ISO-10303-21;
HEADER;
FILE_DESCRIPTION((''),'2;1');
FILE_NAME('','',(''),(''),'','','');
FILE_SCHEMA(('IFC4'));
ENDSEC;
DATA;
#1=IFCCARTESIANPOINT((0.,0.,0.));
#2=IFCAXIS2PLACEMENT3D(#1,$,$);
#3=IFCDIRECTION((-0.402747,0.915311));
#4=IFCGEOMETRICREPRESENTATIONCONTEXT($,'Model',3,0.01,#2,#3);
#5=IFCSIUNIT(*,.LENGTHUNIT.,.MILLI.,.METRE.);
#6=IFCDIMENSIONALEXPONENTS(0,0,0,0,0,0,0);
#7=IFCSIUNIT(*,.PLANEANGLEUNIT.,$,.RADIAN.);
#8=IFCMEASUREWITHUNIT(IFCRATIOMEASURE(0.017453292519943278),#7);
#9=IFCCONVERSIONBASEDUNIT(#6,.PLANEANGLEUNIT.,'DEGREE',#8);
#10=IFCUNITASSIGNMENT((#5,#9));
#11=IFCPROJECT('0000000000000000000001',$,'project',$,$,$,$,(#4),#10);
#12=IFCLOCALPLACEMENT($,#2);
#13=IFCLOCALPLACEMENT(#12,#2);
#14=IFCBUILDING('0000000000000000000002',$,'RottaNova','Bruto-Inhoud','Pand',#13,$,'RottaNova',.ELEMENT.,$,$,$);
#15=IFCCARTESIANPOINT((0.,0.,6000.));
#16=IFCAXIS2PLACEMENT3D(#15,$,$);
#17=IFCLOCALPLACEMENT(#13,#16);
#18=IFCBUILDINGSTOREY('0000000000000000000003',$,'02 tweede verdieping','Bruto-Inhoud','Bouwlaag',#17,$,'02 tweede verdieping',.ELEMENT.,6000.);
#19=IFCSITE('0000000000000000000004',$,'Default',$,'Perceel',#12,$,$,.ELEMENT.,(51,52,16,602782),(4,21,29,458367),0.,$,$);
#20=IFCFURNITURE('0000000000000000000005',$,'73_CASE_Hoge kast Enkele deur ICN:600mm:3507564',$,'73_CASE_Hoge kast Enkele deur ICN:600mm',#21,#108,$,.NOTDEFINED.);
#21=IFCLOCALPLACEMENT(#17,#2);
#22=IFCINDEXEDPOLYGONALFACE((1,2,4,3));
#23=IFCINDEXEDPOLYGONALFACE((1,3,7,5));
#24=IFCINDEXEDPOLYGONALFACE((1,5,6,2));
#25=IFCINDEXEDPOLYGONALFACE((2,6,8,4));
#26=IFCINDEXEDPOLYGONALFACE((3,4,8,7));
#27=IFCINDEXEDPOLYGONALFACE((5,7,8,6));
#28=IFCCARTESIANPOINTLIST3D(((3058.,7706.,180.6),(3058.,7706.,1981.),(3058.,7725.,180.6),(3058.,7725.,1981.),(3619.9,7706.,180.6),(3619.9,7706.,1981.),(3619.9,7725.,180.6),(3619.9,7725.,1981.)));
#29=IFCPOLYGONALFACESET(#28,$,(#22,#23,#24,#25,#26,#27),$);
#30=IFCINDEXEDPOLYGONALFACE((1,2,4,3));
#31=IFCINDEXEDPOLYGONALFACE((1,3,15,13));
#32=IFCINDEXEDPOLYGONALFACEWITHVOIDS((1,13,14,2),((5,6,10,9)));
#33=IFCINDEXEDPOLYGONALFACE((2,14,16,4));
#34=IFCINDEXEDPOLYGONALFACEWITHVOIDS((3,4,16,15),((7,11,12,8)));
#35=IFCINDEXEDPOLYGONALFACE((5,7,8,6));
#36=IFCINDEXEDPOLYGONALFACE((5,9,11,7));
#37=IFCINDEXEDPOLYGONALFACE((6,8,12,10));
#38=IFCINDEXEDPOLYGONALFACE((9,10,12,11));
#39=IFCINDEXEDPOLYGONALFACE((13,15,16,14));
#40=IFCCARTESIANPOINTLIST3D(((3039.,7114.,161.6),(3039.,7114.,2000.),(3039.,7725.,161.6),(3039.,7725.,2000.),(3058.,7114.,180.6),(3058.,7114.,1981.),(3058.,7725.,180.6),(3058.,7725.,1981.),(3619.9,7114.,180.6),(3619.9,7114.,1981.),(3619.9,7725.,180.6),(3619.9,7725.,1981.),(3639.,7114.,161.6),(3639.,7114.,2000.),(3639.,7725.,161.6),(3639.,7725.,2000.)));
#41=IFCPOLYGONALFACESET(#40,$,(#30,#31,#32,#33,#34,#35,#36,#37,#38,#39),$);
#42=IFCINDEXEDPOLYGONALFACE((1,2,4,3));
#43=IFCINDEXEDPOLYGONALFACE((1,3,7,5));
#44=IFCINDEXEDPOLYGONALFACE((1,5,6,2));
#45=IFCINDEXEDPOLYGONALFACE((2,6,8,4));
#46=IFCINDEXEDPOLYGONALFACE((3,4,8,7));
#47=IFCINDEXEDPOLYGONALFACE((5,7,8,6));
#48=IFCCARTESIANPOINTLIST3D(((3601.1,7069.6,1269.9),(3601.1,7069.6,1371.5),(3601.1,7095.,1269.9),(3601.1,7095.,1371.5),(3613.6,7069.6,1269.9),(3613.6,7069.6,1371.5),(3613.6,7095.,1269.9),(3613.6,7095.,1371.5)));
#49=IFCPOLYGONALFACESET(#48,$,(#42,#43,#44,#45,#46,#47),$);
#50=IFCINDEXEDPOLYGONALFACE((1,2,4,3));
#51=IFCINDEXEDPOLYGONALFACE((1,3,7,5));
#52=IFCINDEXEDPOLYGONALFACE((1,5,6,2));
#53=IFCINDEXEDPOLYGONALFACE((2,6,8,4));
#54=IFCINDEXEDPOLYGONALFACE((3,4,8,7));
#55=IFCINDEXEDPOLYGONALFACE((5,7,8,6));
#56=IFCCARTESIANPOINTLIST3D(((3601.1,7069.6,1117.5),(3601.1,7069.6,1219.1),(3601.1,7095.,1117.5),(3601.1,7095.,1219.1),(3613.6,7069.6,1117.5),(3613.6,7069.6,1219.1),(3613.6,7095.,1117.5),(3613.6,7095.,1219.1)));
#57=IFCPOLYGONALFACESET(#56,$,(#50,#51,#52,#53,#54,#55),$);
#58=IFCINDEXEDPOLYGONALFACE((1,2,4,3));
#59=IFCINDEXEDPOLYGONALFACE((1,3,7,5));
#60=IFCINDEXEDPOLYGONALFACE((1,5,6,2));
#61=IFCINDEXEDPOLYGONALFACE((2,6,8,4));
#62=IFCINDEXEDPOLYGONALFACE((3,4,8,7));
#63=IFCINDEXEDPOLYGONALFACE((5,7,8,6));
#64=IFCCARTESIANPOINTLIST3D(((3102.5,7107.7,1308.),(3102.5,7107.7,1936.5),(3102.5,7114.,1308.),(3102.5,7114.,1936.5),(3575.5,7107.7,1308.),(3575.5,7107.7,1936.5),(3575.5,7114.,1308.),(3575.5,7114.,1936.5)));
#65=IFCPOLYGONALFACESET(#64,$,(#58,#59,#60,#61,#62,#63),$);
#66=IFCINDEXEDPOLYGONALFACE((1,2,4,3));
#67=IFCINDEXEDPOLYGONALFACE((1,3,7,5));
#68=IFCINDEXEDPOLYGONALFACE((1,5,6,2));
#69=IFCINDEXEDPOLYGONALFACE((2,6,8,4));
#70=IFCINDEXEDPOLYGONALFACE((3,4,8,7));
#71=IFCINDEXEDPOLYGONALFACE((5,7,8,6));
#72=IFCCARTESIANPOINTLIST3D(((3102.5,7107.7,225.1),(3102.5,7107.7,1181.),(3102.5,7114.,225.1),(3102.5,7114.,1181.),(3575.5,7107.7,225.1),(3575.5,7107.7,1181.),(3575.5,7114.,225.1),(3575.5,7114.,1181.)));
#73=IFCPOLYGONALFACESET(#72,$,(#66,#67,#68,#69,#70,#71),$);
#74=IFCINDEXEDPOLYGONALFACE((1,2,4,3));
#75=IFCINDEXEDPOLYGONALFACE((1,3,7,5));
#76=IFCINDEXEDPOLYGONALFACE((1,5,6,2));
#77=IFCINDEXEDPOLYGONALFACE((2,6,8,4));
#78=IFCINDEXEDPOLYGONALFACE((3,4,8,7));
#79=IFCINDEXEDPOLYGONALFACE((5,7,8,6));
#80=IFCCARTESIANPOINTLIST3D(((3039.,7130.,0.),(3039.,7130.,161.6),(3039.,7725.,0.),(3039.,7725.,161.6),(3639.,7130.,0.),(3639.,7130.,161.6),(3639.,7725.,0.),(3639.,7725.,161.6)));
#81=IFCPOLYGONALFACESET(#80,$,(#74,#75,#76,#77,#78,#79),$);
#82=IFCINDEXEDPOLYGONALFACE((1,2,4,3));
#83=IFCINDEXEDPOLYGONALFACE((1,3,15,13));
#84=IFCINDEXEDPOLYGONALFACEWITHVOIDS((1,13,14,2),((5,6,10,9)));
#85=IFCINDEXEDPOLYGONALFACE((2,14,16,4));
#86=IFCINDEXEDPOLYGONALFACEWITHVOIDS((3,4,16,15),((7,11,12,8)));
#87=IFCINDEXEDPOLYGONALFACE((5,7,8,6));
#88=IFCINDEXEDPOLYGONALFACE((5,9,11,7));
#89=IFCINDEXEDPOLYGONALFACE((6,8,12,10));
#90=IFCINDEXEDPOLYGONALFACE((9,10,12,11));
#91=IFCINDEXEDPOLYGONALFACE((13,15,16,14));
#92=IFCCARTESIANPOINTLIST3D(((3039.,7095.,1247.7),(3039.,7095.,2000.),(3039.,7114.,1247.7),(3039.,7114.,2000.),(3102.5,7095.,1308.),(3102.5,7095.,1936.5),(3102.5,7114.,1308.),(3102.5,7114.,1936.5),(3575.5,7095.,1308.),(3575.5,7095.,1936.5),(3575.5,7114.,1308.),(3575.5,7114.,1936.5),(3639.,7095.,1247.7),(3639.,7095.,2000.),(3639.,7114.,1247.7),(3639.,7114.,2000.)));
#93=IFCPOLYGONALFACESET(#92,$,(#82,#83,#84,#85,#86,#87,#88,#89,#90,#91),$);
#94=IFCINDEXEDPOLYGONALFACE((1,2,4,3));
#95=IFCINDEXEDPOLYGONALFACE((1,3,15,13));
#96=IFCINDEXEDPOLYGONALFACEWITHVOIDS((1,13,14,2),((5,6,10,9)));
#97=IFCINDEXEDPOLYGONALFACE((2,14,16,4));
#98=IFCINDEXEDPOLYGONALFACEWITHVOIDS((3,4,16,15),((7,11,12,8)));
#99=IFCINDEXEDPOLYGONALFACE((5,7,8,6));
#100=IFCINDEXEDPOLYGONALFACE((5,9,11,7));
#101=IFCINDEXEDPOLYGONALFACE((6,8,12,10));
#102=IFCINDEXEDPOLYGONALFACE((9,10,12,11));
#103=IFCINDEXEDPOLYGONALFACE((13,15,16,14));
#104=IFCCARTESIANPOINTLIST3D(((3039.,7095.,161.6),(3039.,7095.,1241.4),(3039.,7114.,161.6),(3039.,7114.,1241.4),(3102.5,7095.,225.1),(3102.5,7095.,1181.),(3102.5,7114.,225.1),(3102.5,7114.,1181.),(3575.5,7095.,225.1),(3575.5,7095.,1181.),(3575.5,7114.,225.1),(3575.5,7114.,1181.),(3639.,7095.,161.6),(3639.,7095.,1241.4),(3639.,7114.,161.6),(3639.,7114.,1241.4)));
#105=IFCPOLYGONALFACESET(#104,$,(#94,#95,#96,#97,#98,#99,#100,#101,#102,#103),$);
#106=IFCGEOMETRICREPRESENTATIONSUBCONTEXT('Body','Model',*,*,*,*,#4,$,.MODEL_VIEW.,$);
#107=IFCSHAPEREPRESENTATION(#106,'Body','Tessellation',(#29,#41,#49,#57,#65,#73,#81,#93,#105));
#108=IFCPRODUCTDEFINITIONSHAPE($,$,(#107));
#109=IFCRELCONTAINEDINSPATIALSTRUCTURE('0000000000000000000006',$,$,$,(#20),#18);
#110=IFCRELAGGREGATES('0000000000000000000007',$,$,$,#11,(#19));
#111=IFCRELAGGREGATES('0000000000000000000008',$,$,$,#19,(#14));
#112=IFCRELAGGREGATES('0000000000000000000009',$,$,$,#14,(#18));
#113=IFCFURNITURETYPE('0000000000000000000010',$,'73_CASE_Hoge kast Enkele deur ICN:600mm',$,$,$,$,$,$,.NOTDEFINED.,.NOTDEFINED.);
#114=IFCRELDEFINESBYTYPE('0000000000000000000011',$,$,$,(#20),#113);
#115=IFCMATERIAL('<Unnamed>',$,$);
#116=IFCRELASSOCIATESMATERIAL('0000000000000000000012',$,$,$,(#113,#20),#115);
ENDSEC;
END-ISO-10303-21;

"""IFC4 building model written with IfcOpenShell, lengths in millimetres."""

from ifc_helpers import new_model, entity, si_unit, converted_unit, direction, frame, frame_2d, origin, origin_2d_with_axis, place, context, subcontext, project, spatial, polyline, rectangle, outline, extrude, source, transform, mapped, material, type_object, type_shapes, element, save


model = new_model("IFC4")

# Units and contexts
model_context = context("Model", 3, precision=0.01, world=origin(), true_north=direction((-0.402747, 0.915311)))
body_context = subcontext(model_context, "Body", "Model", "MODEL_VIEW")
ifc_project = project(units=[si_unit("LENGTHUNIT", "METRE", prefix="MILLI"), converted_unit("PLANEANGLEUNIT", "DEGREE", entity("IfcRatioMeasure", 0.017453292519943278), si_unit("PLANEANGLEUNIT", "RADIAN"), dimensions=[0, 0, 0, 0, 0, 0, 0])], contexts=[model_context])

# Site, building, storey
site_placement = place(None, origin())
site = spatial("IfcSite", under=ifc_project, at=site_placement, Name="Default", ObjectType="Perceel", CompositionType="ELEMENT", RefLatitude=(51, 52, 16, 602782), RefLongitude=(4, 21, 29, 458367), RefElevation=0.0)
building_placement = place(site_placement, origin())
building = spatial("IfcBuilding", under=site, at=building_placement, Name="RottaNova", Description="Bruto-Inhoud", ObjectType="Pand", LongName="RottaNova", CompositionType="ELEMENT")
storey_placement = place(building_placement, frame((0.0, 0.0, 6000.0)))
storey = spatial("IfcBuildingStorey", under=building, at=storey_placement, Name="02 tweede verdieping", Description="Bruto-Inhoud", ObjectType="Bouwlaag", LongName="02 tweede verdieping", CompositionType="ELEMENT", Elevation=6000.0)

# Furniture
ifc_material_1 = material(Name="<Unnamed>")
furniture_type = type_object("IfcFurnitureType", Name="73_CASE_Hoge kast Enkele deur ICN:600mm", AssemblyPlace="NOTDEFINED", PredefinedType="NOTDEFINED", material=ifc_material_1)
shared_shape_1 = source(origin(), body_context, "Body", "SweptSolid", [
    extrude(rectangle(XDim=19.1, YDim=561.9, at=origin_2d_with_axis()), frame((18.7, -9.5, 180.6), z_axis=(0.0, 0.0, 1.0), x_axis=(0.0, 1.0, 0.0)), (0.0, 0.0, 1.0), 1800.3),
    extrude(outline(polyline([(-300.0, -919.2), (300.0, -919.2), (300.0, 919.2), (-300.0, 919.2), (-300.0, -919.2)]), holes=[polyline([(-280.9, 900.2), (281.0, 900.2), (281.0, -900.2), (-280.9, -900.2), (-280.9, 900.2)])]), frame((18.7, -610.9, 1080.8), z_axis=(0.0, 1.0, 0.0), x_axis=(-1.0, 0.0, 0.0)), (0.0, 0.0, 1.0), 610.9),
    extrude(rectangle(XDim=25.4, YDim=12.5, at=frame_2d((0.0, 0.0), x_axis=(1.0, 0.0))), frame((287.1, -642.7, 1269.9), z_axis=(0.0, 0.0, 1.0), x_axis=(0.0, 1.0, 0.0)), (0.0, 0.0, 1.0), 101.6),
    extrude(rectangle(XDim=25.4, YDim=12.5, at=frame_2d((0.0, 0.0), x_axis=(1.0, 0.0))), frame((287.1, -642.7, 1117.5), z_axis=(0.0, 0.0, 1.0), x_axis=(0.0, 1.0, 0.0)), (0.0, 0.0, 1.0), 101.6),
    extrude(rectangle(XDim=6.4, YDim=473.0, at=frame_2d((0.0, 0.0), x_axis=(1.0, 0.0))), frame((18.7, -614.1, 1308.0), z_axis=(0.0, 0.0, 1.0), x_axis=(0.0, 1.0, 0.0)), (0.0, 0.0, 1.0), 628.5),
    extrude(rectangle(XDim=6.4, YDim=473.0, at=origin_2d_with_axis()), frame((18.7, -614.1, 225.1), z_axis=(0.0, 0.0, 1.0), x_axis=(0.0, 1.0, 0.0)), (0.0, 0.0, 1.0), 956.0),
    extrude(rectangle(XDim=600.0, YDim=595.0, at=frame_2d((0.0, 0.0), x_axis=(1.0, 0.0))), frame((18.7, -297.5, 0.0), z_axis=(0.0, 0.0, 1.0), x_axis=(-1.0, 0.0, 0.0)), (0.0, 0.0, 1.0), 161.6),
    extrude(outline(polyline([(-376.1, -300.0), (376.1, -300.0), (376.1, 300.0), (-376.1, 300.0), (-376.1, -300.0)]), holes=[polyline([(-312.6, -236.5), (-312.6, 236.5), (315.8, 236.5), (315.8, -236.5), (-312.6, -236.5)])]), frame((18.7, -630.0, 1623.9), z_axis=(0.0, 1.0, 0.0), x_axis=(0.0, 0.0, -1.0)), (0.0, 0.0, 1.0), 19.1),
    extrude(outline(polyline([(-300.0, -539.9), (300.0, -539.9), (300.0, 539.9), (-300.0, 539.9), (-300.0, -539.9)]), holes=[polyline([(-236.5, 479.6), (236.5, 479.6), (236.5, -476.4), (-236.5, -476.4), (-236.5, 479.6)])]), frame((18.7, -630.0, 701.5), z_axis=(0.0, 1.0, 0.0), x_axis=(-1.0, 0.0, 0.0)), (0.0, 0.0, 1.0), 19.1),
])
type_shapes(furniture_type, [shared_shape_1])
for number, where, name in (
    (1, (3320.3, 7725.0, 0.0), "73_CASE_Hoge kast Enkele deur ICN:600mm:3507564"),
):
    element("IfcFurniture", number, at=place(storey_placement, frame(where)), inside=storey, type_object=furniture_type, material=ifc_material_1, Name=name, ObjectType="73_CASE_Hoge kast Enkele deur ICN:600mm", PredefinedType="NOTDEFINED", context=body_context, shape_type="MappedRepresentation", body=[
        mapped(shared_shape_1, transform((0.0, 0.0, 0.0), scale=1.0)),
    ])

save(model, "model.ifc")
